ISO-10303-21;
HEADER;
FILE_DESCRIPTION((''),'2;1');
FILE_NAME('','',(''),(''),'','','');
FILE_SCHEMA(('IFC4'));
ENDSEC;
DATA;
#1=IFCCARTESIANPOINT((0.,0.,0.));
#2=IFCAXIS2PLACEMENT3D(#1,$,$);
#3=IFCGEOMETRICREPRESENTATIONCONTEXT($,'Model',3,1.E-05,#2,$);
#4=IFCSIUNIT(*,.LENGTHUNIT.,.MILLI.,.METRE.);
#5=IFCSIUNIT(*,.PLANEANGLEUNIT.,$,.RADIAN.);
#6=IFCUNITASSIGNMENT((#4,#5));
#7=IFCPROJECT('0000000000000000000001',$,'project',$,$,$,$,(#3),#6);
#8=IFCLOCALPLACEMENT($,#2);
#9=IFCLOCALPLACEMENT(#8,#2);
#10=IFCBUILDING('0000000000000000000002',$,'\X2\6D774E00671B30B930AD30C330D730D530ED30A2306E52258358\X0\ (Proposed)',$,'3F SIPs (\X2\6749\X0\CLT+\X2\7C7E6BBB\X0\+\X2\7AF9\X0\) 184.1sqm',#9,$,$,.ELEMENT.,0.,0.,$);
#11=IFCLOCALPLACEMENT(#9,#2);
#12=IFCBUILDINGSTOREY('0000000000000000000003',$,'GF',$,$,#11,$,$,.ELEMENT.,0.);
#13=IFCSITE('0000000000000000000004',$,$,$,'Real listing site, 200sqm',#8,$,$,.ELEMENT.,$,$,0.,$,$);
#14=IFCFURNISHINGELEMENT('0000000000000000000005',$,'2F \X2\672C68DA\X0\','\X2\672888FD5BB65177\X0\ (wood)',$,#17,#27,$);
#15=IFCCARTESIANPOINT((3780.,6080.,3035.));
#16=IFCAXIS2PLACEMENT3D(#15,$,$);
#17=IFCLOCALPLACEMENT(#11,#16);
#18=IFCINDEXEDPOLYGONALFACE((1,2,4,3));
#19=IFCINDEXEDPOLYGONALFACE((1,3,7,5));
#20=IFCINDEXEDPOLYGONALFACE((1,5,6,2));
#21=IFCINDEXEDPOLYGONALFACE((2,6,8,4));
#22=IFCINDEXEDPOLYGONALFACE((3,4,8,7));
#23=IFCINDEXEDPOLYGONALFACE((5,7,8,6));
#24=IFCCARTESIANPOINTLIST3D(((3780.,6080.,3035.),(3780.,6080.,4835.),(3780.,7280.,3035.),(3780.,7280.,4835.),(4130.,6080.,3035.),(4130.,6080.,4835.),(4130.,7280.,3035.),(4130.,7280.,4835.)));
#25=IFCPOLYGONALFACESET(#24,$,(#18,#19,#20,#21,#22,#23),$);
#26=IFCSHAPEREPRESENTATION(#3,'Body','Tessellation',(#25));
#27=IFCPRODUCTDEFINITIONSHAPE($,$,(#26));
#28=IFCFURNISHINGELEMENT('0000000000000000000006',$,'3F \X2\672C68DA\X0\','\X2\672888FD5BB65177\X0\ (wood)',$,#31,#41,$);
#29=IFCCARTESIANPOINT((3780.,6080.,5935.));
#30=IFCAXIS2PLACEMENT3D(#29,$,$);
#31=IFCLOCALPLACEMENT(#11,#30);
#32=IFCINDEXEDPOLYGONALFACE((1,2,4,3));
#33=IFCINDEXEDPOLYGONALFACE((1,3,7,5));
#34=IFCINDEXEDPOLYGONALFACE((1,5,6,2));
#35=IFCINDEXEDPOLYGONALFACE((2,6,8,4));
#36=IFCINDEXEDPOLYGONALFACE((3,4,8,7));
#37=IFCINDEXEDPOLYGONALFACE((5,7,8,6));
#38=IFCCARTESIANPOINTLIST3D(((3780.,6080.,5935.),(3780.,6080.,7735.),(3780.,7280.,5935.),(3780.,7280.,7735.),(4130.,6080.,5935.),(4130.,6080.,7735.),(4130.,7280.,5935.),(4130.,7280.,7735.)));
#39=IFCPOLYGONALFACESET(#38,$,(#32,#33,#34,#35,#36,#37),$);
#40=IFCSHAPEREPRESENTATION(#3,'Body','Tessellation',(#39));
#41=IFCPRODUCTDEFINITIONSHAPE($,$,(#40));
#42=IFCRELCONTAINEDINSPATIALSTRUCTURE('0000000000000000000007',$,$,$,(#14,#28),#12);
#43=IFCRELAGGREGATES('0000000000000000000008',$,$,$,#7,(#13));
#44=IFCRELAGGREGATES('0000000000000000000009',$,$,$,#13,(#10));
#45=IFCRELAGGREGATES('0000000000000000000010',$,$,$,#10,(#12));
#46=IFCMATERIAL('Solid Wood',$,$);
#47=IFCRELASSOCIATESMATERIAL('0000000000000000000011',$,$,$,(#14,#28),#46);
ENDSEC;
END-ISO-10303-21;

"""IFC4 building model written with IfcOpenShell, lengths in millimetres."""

from ifc_helpers import new_model, si_unit, frame, frame_2d, origin, place, context, project, spatial, rectangle, extrude, material, element, save


model = new_model("IFC4")

# Units and contexts
model_context = context("Model", 3, precision=1e-05, world=origin())
ifc_project = project(units=[si_unit("LENGTHUNIT", "METRE", prefix="MILLI"), si_unit("PLANEANGLEUNIT", "RADIAN")], contexts=[model_context])

# Site, building, storey
site_placement = place(None, origin())
site = spatial("IfcSite", under=ifc_project, at=site_placement, ObjectType="Real listing site, 200sqm", CompositionType="ELEMENT", RefElevation=0.0)
building_placement = place(site_placement, origin())
building = spatial("IfcBuilding", under=site, at=building_placement, Name="海一望スキップフロアの別荘 (Proposed)", ObjectType="3F SIPs (杉CLT+籾殻+竹) 184.1sqm", CompositionType="ELEMENT", ElevationOfRefHeight=0.0, ElevationOfTerrain=0.0)
storey_placement = place(building_placement, origin())
storey = spatial("IfcBuildingStorey", under=building, at=storey_placement, Name="GF", CompositionType="ELEMENT", Elevation=0.0)

# Shared definitions
ifc_material_1 = material(Name="Solid Wood")

# Furnishing elements
furnishing_1_placement = place(storey_placement, frame((3780.0, 6080.0, 3035.0)))
element("IfcFurnishingElement", 1, at=furnishing_1_placement, inside=storey, material=ifc_material_1, Name="2F 本棚", Description="木製家具 (wood)", context=model_context, shape_type="SweptSolid", body=[
    extrude(rectangle(XDim=350.0, YDim=1200.0, at=frame_2d((175.0, 600.0))), frame((3780.0, 6080.0, 3035.0)), (0.0, 0.0, 1.0), 1800.0),
])
furnishing_2_placement = place(storey_placement, frame((3780.0, 6080.0, 5935.0)))
element("IfcFurnishingElement", 2, at=furnishing_2_placement, inside=storey, material=ifc_material_1, Name="3F 本棚", Description="木製家具 (wood)", context=model_context, shape_type="SweptSolid", body=[
    extrude(rectangle(XDim=350.0, YDim=1200.0, at=frame_2d((175.0, 600.0))), frame((3780.0, 6080.0, 5935.0)), (0.0, 0.0, 1.0), 1800.0),
])

save(model, "model.ifc")
